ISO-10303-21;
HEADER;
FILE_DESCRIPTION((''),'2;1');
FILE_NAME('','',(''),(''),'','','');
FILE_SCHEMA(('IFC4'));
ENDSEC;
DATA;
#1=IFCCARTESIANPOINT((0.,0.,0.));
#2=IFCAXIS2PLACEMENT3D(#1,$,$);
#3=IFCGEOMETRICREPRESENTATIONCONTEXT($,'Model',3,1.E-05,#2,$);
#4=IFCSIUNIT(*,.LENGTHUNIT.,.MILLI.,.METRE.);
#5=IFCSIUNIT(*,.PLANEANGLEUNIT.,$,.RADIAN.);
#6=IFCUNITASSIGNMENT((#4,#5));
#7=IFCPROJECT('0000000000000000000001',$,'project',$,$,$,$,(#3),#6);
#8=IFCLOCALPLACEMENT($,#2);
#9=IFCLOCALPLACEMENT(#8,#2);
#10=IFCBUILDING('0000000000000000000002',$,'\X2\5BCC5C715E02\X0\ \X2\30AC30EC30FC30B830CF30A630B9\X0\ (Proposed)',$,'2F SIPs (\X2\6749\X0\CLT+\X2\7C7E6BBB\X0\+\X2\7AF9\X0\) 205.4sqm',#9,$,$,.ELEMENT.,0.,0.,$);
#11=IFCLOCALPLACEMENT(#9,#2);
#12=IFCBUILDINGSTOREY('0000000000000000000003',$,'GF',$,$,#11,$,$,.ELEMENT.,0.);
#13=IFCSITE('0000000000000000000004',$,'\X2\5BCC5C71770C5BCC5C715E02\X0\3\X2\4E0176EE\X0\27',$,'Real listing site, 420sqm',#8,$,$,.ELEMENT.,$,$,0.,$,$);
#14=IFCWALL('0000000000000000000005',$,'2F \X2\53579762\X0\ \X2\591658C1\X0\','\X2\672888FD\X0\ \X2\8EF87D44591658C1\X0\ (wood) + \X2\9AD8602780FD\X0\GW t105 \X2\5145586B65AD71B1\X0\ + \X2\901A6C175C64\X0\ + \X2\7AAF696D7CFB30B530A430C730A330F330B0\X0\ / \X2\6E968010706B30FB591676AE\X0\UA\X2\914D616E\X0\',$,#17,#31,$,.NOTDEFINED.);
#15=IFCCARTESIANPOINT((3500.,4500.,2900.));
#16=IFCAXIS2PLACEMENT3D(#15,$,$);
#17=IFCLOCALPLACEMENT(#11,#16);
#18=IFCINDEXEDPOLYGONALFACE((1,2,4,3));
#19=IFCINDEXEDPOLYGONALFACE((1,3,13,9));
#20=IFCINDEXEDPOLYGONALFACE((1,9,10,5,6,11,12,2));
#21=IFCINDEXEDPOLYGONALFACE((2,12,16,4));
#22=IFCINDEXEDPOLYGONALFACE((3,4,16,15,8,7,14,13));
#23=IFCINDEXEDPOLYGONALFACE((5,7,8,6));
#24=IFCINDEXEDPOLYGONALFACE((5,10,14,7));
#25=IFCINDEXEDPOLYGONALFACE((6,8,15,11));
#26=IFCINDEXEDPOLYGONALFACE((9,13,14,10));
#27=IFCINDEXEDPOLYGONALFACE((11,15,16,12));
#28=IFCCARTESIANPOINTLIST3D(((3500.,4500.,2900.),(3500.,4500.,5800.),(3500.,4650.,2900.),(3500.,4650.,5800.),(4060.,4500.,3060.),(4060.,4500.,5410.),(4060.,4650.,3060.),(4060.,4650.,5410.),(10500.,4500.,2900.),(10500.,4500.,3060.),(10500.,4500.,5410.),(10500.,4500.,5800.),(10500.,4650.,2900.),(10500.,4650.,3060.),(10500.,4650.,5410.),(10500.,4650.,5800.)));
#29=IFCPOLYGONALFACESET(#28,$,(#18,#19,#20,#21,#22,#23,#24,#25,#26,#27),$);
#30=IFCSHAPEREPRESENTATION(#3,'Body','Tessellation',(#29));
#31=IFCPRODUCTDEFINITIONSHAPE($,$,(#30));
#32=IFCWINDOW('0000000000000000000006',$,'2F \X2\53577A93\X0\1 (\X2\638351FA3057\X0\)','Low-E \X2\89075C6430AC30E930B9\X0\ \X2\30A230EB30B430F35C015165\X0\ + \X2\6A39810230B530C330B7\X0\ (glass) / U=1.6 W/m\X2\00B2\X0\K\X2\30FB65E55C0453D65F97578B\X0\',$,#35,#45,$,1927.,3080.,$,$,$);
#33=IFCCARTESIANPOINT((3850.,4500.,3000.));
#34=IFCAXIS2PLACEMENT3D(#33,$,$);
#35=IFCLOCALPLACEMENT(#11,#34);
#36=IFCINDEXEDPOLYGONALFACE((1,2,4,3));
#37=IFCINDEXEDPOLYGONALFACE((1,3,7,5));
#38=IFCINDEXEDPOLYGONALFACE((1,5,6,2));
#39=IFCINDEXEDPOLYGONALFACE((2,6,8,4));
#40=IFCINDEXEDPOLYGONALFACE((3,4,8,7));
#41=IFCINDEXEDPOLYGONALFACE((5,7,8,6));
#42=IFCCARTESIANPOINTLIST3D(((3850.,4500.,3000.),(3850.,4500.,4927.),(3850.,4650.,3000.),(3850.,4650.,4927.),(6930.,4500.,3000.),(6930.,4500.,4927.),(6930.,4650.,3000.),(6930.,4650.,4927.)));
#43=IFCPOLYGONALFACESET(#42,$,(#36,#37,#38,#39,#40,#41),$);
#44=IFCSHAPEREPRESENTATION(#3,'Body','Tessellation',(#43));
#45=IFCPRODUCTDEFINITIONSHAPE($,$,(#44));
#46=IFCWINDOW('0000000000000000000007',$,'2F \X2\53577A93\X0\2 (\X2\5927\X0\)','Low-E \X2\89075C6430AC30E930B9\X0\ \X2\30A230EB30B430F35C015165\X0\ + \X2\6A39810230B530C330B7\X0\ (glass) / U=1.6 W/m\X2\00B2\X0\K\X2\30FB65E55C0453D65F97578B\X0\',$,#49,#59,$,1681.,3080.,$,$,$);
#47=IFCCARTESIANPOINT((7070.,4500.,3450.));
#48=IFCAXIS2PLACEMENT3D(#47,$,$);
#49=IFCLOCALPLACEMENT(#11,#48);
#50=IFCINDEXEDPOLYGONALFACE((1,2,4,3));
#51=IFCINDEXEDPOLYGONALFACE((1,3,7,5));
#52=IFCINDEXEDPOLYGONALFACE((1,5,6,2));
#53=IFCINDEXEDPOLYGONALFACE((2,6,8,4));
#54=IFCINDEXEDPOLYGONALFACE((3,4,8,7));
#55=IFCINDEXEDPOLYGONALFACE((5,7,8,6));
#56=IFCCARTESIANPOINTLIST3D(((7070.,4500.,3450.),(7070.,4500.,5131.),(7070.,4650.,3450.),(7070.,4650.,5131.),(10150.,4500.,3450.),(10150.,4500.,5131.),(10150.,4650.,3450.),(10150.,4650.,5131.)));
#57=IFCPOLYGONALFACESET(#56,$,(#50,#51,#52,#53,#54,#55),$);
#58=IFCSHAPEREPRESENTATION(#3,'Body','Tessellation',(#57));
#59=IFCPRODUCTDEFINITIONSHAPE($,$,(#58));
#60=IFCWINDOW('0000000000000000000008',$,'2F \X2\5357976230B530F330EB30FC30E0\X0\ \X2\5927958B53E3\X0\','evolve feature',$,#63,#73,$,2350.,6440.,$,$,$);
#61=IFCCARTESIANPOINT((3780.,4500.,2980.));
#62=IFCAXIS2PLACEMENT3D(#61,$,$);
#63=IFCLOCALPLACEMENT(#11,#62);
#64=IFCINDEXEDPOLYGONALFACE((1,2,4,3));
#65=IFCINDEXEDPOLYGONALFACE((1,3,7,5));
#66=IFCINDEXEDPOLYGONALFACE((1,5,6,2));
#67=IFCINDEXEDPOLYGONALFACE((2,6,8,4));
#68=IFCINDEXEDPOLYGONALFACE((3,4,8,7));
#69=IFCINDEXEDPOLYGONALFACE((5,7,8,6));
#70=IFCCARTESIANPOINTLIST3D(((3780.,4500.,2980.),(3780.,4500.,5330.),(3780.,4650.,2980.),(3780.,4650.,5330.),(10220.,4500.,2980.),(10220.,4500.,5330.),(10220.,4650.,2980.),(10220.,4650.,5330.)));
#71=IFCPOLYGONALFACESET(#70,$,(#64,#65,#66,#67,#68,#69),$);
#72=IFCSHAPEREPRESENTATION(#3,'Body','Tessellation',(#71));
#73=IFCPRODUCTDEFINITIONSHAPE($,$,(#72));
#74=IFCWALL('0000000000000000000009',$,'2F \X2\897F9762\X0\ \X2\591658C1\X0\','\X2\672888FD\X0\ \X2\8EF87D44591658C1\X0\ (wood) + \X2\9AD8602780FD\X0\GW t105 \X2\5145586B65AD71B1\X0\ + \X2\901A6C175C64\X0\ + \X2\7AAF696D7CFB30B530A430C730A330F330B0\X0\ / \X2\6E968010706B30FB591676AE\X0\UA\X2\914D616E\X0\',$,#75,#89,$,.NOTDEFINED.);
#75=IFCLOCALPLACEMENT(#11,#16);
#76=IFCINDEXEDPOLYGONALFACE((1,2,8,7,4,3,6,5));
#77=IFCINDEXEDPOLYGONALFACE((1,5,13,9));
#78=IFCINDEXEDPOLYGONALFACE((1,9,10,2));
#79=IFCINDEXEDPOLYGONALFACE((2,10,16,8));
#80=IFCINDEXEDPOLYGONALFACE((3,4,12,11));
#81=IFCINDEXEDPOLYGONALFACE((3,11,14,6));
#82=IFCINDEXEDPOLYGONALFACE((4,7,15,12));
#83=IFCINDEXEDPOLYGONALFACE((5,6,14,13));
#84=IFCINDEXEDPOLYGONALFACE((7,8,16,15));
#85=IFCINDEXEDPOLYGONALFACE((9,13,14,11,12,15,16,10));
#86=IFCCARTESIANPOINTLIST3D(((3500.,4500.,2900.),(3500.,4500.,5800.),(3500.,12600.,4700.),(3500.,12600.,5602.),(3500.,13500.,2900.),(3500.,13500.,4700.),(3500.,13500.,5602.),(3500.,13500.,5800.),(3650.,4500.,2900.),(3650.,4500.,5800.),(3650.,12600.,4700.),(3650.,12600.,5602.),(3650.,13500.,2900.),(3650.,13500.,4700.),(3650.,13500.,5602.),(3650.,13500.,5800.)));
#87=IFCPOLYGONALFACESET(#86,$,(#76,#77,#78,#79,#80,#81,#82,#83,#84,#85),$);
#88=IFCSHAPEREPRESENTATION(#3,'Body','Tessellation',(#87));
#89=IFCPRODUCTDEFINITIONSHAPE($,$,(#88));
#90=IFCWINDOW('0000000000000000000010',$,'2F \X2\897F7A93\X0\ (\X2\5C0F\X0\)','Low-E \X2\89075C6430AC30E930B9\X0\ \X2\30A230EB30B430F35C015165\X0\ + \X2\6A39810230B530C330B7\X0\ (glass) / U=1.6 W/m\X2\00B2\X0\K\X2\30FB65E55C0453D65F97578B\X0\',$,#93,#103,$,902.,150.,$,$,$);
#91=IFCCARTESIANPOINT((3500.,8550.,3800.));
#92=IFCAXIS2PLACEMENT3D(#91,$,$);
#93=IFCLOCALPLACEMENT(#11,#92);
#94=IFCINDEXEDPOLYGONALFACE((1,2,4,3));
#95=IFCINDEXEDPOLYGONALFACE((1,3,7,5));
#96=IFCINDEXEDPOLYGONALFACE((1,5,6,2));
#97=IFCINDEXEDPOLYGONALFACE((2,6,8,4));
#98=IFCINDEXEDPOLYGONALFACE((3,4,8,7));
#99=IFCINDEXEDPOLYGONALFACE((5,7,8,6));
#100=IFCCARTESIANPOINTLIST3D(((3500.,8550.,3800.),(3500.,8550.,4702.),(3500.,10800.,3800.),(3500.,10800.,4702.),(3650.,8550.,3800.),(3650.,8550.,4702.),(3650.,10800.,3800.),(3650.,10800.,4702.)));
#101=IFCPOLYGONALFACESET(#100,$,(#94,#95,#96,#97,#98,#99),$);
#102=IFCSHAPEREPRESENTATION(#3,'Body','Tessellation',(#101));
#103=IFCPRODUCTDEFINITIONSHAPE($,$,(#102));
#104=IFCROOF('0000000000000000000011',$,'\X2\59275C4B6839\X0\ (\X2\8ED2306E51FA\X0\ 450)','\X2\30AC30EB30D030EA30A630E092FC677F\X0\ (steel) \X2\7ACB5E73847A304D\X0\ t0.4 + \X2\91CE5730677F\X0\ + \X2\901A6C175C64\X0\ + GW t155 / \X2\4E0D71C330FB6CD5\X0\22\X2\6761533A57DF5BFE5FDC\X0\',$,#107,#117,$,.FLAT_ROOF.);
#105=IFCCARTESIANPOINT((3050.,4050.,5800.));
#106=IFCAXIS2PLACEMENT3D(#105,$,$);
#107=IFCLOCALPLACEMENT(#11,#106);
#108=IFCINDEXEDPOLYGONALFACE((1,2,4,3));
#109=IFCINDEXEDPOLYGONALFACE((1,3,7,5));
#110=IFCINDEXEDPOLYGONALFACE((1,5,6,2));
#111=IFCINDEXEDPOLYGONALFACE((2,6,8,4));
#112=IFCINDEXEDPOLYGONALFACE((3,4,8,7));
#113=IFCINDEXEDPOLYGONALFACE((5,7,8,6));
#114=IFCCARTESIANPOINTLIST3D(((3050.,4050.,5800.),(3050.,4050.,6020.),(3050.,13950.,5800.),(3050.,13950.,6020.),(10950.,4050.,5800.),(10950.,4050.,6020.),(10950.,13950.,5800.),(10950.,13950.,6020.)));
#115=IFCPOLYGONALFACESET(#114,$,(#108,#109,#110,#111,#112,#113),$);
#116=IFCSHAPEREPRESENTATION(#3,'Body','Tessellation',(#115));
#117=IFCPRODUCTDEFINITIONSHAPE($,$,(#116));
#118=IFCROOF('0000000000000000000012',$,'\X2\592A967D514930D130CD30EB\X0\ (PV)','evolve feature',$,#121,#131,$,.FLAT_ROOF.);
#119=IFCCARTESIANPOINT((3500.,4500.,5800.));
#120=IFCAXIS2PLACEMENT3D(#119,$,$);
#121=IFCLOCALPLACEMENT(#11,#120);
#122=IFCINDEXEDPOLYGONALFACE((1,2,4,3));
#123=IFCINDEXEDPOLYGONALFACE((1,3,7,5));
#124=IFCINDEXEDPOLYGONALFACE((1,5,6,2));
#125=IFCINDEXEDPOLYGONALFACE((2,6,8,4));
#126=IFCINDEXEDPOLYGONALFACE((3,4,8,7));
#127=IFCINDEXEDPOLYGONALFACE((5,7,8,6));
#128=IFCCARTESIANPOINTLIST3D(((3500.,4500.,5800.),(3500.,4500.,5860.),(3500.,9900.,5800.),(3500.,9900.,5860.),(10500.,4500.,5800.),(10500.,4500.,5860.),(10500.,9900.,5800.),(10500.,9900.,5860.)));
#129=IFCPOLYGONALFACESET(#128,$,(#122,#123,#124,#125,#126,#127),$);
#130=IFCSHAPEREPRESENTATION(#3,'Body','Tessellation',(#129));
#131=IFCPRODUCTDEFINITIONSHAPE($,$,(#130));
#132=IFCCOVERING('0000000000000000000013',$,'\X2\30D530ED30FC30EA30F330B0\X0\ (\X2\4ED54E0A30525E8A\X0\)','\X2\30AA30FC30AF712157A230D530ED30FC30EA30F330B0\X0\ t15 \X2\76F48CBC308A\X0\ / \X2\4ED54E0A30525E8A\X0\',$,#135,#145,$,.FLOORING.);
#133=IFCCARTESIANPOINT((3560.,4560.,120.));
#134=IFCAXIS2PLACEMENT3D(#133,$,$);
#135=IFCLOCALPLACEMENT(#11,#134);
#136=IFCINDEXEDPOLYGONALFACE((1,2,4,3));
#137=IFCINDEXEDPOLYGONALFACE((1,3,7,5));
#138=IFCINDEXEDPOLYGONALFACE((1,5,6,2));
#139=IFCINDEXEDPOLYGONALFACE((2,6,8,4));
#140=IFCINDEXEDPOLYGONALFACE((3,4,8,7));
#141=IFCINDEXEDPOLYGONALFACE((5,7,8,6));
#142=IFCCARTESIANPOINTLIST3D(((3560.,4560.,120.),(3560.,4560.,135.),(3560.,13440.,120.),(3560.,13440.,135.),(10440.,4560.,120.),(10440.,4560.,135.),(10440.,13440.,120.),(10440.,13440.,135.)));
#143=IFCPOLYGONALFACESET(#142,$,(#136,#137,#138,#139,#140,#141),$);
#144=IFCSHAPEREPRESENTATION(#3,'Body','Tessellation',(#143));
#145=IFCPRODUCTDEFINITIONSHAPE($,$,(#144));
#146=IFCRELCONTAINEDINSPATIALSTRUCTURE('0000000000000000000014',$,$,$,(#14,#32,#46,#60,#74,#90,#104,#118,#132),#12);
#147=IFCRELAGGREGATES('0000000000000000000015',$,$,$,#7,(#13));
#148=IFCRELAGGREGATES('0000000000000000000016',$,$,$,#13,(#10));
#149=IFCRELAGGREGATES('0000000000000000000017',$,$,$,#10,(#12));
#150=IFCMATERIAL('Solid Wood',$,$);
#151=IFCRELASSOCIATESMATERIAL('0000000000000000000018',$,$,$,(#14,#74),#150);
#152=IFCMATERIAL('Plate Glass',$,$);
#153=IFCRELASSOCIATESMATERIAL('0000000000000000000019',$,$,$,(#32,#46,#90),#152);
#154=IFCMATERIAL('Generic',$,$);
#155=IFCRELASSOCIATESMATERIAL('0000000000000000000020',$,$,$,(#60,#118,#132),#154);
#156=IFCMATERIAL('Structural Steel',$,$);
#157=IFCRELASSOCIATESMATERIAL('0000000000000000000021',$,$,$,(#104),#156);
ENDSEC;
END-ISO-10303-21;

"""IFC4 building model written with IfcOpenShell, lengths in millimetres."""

from ifc_helpers import new_model, si_unit, frame, frame_2d, origin, place, context, project, spatial, rectangle, extrude, material, element, fill, save


model = new_model("IFC4")

# Units and contexts
model_context = context("Model", 3, precision=1e-05, world=origin())
ifc_project = project(units=[si_unit("LENGTHUNIT", "METRE", prefix="MILLI"), si_unit("PLANEANGLEUNIT", "RADIAN")], contexts=[model_context])

# Site, building, storey
site_placement = place(None, origin())
site = spatial("IfcSite", under=ifc_project, at=site_placement, Name="富山県富山市3丁目27", ObjectType="Real listing site, 420sqm", CompositionType="ELEMENT", RefElevation=0.0)
building_placement = place(site_placement, origin())
building = spatial("IfcBuilding", under=site, at=building_placement, Name="富山市 ガレージハウス (Proposed)", ObjectType="2F SIPs (杉CLT+籾殻+竹) 205.4sqm", CompositionType="ELEMENT", ElevationOfRefHeight=0.0, ElevationOfTerrain=0.0)
storey_placement = place(building_placement, origin())
storey = spatial("IfcBuildingStorey", under=building, at=storey_placement, Name="GF", CompositionType="ELEMENT", Elevation=0.0)

# Shared definitions
ifc_material_1 = material(Name="Solid Wood")

# Shared definitions
ifc_material_2 = material(Name="Plate Glass")
ifc_material_3 = material(Name="Generic")

# Wall, openings, windows
wall_1_placement = place(storey_placement, frame((3500.0, 4500.0, 2900.0)))
wall_1 = element("IfcWall", 1, at=wall_1_placement, inside=storey, material=ifc_material_1, Name="2F 南面 外壁", Description="木製 軸組外壁 (wood) + 高性能GW t105 充填断熱 + 通気層 + 窯業系サイディング / 準耐火・外皮UA配慮", PredefinedType="NOTDEFINED", context=model_context, shape_type="SweptSolid", body=[
    extrude(rectangle(XDim=7000.0, YDim=150.0, at=frame_2d((3500.0, 75.0))), frame((3500.0, 4500.0, 2900.0)), (0.0, 0.0, 1.0), 2900.0),
])
opening_1_placement = place(storey_placement, frame((3850.0, 4500.0, 3000.0)))
opening_1 = element("IfcOpeningElement", 2, at=opening_1_placement, cuts=wall_1, PredefinedType="NOTDEFINED", context=model_context, shape_type="SweptSolid", body=[
    extrude(rectangle(XDim=3080.0, YDim=150.0, at=frame_2d((1540.0, 75.0))), frame((3850.0, 4500.0, 3000.0)), (0.0, 0.0, 1.0), 1927.0),
])
opening_2_placement = place(storey_placement, frame((7070.0, 4500.0, 3450.0)))
opening_2 = element("IfcOpeningElement", 3, at=opening_2_placement, cuts=wall_1, PredefinedType="NOTDEFINED", context=model_context, shape_type="SweptSolid", body=[
    extrude(rectangle(XDim=3080.0, YDim=150.0, at=frame_2d((1540.0, 75.0))), frame((7070.0, 4500.0, 3450.0)), (0.0, 0.0, 1.0), 1681.0),
])
opening_3_placement = place(storey_placement, frame((3780.0, 4500.0, 2980.0)))
opening_3 = element("IfcOpeningElement", 4, at=opening_3_placement, cuts=wall_1, PredefinedType="NOTDEFINED", context=model_context, shape_type="SweptSolid", body=[
    extrude(rectangle(XDim=6440.0, YDim=150.0, at=frame_2d((3220.0, 75.0))), frame((3780.0, 4500.0, 2980.0)), (0.0, 0.0, 1.0), 2350.0),
])
window_1_placement = place(storey_placement, frame((3850.0, 4500.0, 3000.0)))
window_1 = element("IfcWindow", 5, at=window_1_placement, inside=storey, material=ifc_material_2, Name="2F 南窓1 (掃出し)", Description="Low-E 複層ガラス アルゴン封入 + 樹脂サッシ (glass) / U=1.6 W/m²K・日射取得型", OverallHeight=1927.0, OverallWidth=3080.0, context=model_context, shape_type="SweptSolid", body=[
    extrude(rectangle(XDim=3080.0, YDim=150.0, at=frame_2d((1540.0, 75.0))), frame((3850.0, 4500.0, 3000.0)), (0.0, 0.0, 1.0), 1927.0),
])
fill(opening_1, window_1)
window_2_placement = place(storey_placement, frame((7070.0, 4500.0, 3450.0)))
window_2 = element("IfcWindow", 6, at=window_2_placement, inside=storey, material=ifc_material_2, Name="2F 南窓2 (大)", Description="Low-E 複層ガラス アルゴン封入 + 樹脂サッシ (glass) / U=1.6 W/m²K・日射取得型", OverallHeight=1681.0, OverallWidth=3080.0, context=model_context, shape_type="SweptSolid", body=[
    extrude(rectangle(XDim=3080.0, YDim=150.0, at=frame_2d((1540.0, 75.0))), frame((7070.0, 4500.0, 3450.0)), (0.0, 0.0, 1.0), 1681.0),
])
fill(opening_2, window_2)
window_3_placement = place(storey_placement, frame((3780.0, 4500.0, 2980.0)))
window_3 = element("IfcWindow", 7, at=window_3_placement, inside=storey, material=ifc_material_3, Name="2F 南面サンルーム 大開口", Description="evolve feature", OverallHeight=2350.0, OverallWidth=6440.0, context=model_context, shape_type="SweptSolid", body=[
    extrude(rectangle(XDim=6440.0, YDim=150.0, at=frame_2d((3220.0, 75.0))), frame((3780.0, 4500.0, 2980.0)), (0.0, 0.0, 1.0), 2350.0),
])
fill(opening_3, window_3)

# Wall, opening, window
wall_2_placement = place(storey_placement, frame((3500.0, 4500.0, 2900.0)))
wall_2 = element("IfcWall", 8, at=wall_2_placement, inside=storey, material=ifc_material_1, Name="2F 西面 外壁", Description="木製 軸組外壁 (wood) + 高性能GW t105 充填断熱 + 通気層 + 窯業系サイディング / 準耐火・外皮UA配慮", PredefinedType="NOTDEFINED", context=model_context, shape_type="SweptSolid", body=[
    extrude(rectangle(XDim=150.0, YDim=9000.0, at=frame_2d((75.0, 4500.0))), frame((3500.0, 4500.0, 2900.0)), (0.0, 0.0, 1.0), 2900.0),
])
opening_4_placement = place(storey_placement, frame((3500.0, 8550.0, 3800.0)))
opening_4 = element("IfcOpeningElement", 9, at=opening_4_placement, cuts=wall_2, PredefinedType="NOTDEFINED", context=model_context, shape_type="SweptSolid", body=[
    extrude(rectangle(XDim=150.0, YDim=2250.0, at=frame_2d((75.0, 1125.0))), frame((3500.0, 8550.0, 3800.0)), (0.0, 0.0, 1.0), 902.0),
])
window_4_placement = place(storey_placement, frame((3500.0, 8550.0, 3800.0)))
window_4 = element("IfcWindow", 10, at=window_4_placement, inside=storey, material=ifc_material_2, Name="2F 西窓 (小)", Description="Low-E 複層ガラス アルゴン封入 + 樹脂サッシ (glass) / U=1.6 W/m²K・日射取得型", OverallHeight=902.0, OverallWidth=150.0, context=model_context, shape_type="SweptSolid", body=[
    extrude(rectangle(XDim=150.0, YDim=2250.0, at=frame_2d((75.0, 1125.0))), frame((3500.0, 8550.0, 3800.0)), (0.0, 0.0, 1.0), 902.0),
])
fill(opening_4, window_4)

# Roofs
ifc_material_4 = material(Name="Structural Steel")
roof_1_placement = place(storey_placement, frame((3050.0, 4050.0, 5800.0)))
element("IfcRoof", 11, at=roof_1_placement, inside=storey, material=ifc_material_4, Name="大屋根 (軒の出 450)", Description="ガルバリウム鋼板 (steel) 立平葺き t0.4 + 野地板 + 通気層 + GW t155 / 不燃・法22条区域対応", PredefinedType="FLAT_ROOF", context=model_context, shape_type="SweptSolid", body=[
    extrude(rectangle(XDim=7900.0, YDim=9900.0, at=frame_2d((3950.0, 4950.0))), frame((3050.0, 4050.0, 5800.0)), (0.0, 0.0, 1.0), 220.0),
])
roof_2_placement = place(storey_placement, frame((3500.0, 4500.0, 5800.0)))
element("IfcRoof", 12, at=roof_2_placement, inside=storey, material=ifc_material_3, Name="太陽光パネル (PV)", Description="evolve feature", PredefinedType="FLAT_ROOF", context=model_context, shape_type="SweptSolid", body=[
    extrude(rectangle(XDim=7000.0, YDim=5400.0, at=frame_2d((3500.0, 2700.0))), frame((3500.0, 4500.0, 5800.0)), (0.0, 0.0, 1.0), 60.0),
])

# Covering
covering_placement = place(storey_placement, frame((3560.0, 4560.0, 120.0)))
element("IfcCovering", 13, at=covering_placement, inside=storey, material=ifc_material_3, Name="フローリング (仕上げ床)", Description="オーク無垢フローリング t15 直貼り / 仕上げ床", PredefinedType="FLOORING", context=model_context, shape_type="SweptSolid", body=[
    extrude(rectangle(XDim=6880.0, YDim=8880.0, at=frame_2d((3440.0, 4440.0))), frame((3560.0, 4560.0, 120.0)), (0.0, 0.0, 1.0), 15.0),
])

save(model, "model.ifc")
